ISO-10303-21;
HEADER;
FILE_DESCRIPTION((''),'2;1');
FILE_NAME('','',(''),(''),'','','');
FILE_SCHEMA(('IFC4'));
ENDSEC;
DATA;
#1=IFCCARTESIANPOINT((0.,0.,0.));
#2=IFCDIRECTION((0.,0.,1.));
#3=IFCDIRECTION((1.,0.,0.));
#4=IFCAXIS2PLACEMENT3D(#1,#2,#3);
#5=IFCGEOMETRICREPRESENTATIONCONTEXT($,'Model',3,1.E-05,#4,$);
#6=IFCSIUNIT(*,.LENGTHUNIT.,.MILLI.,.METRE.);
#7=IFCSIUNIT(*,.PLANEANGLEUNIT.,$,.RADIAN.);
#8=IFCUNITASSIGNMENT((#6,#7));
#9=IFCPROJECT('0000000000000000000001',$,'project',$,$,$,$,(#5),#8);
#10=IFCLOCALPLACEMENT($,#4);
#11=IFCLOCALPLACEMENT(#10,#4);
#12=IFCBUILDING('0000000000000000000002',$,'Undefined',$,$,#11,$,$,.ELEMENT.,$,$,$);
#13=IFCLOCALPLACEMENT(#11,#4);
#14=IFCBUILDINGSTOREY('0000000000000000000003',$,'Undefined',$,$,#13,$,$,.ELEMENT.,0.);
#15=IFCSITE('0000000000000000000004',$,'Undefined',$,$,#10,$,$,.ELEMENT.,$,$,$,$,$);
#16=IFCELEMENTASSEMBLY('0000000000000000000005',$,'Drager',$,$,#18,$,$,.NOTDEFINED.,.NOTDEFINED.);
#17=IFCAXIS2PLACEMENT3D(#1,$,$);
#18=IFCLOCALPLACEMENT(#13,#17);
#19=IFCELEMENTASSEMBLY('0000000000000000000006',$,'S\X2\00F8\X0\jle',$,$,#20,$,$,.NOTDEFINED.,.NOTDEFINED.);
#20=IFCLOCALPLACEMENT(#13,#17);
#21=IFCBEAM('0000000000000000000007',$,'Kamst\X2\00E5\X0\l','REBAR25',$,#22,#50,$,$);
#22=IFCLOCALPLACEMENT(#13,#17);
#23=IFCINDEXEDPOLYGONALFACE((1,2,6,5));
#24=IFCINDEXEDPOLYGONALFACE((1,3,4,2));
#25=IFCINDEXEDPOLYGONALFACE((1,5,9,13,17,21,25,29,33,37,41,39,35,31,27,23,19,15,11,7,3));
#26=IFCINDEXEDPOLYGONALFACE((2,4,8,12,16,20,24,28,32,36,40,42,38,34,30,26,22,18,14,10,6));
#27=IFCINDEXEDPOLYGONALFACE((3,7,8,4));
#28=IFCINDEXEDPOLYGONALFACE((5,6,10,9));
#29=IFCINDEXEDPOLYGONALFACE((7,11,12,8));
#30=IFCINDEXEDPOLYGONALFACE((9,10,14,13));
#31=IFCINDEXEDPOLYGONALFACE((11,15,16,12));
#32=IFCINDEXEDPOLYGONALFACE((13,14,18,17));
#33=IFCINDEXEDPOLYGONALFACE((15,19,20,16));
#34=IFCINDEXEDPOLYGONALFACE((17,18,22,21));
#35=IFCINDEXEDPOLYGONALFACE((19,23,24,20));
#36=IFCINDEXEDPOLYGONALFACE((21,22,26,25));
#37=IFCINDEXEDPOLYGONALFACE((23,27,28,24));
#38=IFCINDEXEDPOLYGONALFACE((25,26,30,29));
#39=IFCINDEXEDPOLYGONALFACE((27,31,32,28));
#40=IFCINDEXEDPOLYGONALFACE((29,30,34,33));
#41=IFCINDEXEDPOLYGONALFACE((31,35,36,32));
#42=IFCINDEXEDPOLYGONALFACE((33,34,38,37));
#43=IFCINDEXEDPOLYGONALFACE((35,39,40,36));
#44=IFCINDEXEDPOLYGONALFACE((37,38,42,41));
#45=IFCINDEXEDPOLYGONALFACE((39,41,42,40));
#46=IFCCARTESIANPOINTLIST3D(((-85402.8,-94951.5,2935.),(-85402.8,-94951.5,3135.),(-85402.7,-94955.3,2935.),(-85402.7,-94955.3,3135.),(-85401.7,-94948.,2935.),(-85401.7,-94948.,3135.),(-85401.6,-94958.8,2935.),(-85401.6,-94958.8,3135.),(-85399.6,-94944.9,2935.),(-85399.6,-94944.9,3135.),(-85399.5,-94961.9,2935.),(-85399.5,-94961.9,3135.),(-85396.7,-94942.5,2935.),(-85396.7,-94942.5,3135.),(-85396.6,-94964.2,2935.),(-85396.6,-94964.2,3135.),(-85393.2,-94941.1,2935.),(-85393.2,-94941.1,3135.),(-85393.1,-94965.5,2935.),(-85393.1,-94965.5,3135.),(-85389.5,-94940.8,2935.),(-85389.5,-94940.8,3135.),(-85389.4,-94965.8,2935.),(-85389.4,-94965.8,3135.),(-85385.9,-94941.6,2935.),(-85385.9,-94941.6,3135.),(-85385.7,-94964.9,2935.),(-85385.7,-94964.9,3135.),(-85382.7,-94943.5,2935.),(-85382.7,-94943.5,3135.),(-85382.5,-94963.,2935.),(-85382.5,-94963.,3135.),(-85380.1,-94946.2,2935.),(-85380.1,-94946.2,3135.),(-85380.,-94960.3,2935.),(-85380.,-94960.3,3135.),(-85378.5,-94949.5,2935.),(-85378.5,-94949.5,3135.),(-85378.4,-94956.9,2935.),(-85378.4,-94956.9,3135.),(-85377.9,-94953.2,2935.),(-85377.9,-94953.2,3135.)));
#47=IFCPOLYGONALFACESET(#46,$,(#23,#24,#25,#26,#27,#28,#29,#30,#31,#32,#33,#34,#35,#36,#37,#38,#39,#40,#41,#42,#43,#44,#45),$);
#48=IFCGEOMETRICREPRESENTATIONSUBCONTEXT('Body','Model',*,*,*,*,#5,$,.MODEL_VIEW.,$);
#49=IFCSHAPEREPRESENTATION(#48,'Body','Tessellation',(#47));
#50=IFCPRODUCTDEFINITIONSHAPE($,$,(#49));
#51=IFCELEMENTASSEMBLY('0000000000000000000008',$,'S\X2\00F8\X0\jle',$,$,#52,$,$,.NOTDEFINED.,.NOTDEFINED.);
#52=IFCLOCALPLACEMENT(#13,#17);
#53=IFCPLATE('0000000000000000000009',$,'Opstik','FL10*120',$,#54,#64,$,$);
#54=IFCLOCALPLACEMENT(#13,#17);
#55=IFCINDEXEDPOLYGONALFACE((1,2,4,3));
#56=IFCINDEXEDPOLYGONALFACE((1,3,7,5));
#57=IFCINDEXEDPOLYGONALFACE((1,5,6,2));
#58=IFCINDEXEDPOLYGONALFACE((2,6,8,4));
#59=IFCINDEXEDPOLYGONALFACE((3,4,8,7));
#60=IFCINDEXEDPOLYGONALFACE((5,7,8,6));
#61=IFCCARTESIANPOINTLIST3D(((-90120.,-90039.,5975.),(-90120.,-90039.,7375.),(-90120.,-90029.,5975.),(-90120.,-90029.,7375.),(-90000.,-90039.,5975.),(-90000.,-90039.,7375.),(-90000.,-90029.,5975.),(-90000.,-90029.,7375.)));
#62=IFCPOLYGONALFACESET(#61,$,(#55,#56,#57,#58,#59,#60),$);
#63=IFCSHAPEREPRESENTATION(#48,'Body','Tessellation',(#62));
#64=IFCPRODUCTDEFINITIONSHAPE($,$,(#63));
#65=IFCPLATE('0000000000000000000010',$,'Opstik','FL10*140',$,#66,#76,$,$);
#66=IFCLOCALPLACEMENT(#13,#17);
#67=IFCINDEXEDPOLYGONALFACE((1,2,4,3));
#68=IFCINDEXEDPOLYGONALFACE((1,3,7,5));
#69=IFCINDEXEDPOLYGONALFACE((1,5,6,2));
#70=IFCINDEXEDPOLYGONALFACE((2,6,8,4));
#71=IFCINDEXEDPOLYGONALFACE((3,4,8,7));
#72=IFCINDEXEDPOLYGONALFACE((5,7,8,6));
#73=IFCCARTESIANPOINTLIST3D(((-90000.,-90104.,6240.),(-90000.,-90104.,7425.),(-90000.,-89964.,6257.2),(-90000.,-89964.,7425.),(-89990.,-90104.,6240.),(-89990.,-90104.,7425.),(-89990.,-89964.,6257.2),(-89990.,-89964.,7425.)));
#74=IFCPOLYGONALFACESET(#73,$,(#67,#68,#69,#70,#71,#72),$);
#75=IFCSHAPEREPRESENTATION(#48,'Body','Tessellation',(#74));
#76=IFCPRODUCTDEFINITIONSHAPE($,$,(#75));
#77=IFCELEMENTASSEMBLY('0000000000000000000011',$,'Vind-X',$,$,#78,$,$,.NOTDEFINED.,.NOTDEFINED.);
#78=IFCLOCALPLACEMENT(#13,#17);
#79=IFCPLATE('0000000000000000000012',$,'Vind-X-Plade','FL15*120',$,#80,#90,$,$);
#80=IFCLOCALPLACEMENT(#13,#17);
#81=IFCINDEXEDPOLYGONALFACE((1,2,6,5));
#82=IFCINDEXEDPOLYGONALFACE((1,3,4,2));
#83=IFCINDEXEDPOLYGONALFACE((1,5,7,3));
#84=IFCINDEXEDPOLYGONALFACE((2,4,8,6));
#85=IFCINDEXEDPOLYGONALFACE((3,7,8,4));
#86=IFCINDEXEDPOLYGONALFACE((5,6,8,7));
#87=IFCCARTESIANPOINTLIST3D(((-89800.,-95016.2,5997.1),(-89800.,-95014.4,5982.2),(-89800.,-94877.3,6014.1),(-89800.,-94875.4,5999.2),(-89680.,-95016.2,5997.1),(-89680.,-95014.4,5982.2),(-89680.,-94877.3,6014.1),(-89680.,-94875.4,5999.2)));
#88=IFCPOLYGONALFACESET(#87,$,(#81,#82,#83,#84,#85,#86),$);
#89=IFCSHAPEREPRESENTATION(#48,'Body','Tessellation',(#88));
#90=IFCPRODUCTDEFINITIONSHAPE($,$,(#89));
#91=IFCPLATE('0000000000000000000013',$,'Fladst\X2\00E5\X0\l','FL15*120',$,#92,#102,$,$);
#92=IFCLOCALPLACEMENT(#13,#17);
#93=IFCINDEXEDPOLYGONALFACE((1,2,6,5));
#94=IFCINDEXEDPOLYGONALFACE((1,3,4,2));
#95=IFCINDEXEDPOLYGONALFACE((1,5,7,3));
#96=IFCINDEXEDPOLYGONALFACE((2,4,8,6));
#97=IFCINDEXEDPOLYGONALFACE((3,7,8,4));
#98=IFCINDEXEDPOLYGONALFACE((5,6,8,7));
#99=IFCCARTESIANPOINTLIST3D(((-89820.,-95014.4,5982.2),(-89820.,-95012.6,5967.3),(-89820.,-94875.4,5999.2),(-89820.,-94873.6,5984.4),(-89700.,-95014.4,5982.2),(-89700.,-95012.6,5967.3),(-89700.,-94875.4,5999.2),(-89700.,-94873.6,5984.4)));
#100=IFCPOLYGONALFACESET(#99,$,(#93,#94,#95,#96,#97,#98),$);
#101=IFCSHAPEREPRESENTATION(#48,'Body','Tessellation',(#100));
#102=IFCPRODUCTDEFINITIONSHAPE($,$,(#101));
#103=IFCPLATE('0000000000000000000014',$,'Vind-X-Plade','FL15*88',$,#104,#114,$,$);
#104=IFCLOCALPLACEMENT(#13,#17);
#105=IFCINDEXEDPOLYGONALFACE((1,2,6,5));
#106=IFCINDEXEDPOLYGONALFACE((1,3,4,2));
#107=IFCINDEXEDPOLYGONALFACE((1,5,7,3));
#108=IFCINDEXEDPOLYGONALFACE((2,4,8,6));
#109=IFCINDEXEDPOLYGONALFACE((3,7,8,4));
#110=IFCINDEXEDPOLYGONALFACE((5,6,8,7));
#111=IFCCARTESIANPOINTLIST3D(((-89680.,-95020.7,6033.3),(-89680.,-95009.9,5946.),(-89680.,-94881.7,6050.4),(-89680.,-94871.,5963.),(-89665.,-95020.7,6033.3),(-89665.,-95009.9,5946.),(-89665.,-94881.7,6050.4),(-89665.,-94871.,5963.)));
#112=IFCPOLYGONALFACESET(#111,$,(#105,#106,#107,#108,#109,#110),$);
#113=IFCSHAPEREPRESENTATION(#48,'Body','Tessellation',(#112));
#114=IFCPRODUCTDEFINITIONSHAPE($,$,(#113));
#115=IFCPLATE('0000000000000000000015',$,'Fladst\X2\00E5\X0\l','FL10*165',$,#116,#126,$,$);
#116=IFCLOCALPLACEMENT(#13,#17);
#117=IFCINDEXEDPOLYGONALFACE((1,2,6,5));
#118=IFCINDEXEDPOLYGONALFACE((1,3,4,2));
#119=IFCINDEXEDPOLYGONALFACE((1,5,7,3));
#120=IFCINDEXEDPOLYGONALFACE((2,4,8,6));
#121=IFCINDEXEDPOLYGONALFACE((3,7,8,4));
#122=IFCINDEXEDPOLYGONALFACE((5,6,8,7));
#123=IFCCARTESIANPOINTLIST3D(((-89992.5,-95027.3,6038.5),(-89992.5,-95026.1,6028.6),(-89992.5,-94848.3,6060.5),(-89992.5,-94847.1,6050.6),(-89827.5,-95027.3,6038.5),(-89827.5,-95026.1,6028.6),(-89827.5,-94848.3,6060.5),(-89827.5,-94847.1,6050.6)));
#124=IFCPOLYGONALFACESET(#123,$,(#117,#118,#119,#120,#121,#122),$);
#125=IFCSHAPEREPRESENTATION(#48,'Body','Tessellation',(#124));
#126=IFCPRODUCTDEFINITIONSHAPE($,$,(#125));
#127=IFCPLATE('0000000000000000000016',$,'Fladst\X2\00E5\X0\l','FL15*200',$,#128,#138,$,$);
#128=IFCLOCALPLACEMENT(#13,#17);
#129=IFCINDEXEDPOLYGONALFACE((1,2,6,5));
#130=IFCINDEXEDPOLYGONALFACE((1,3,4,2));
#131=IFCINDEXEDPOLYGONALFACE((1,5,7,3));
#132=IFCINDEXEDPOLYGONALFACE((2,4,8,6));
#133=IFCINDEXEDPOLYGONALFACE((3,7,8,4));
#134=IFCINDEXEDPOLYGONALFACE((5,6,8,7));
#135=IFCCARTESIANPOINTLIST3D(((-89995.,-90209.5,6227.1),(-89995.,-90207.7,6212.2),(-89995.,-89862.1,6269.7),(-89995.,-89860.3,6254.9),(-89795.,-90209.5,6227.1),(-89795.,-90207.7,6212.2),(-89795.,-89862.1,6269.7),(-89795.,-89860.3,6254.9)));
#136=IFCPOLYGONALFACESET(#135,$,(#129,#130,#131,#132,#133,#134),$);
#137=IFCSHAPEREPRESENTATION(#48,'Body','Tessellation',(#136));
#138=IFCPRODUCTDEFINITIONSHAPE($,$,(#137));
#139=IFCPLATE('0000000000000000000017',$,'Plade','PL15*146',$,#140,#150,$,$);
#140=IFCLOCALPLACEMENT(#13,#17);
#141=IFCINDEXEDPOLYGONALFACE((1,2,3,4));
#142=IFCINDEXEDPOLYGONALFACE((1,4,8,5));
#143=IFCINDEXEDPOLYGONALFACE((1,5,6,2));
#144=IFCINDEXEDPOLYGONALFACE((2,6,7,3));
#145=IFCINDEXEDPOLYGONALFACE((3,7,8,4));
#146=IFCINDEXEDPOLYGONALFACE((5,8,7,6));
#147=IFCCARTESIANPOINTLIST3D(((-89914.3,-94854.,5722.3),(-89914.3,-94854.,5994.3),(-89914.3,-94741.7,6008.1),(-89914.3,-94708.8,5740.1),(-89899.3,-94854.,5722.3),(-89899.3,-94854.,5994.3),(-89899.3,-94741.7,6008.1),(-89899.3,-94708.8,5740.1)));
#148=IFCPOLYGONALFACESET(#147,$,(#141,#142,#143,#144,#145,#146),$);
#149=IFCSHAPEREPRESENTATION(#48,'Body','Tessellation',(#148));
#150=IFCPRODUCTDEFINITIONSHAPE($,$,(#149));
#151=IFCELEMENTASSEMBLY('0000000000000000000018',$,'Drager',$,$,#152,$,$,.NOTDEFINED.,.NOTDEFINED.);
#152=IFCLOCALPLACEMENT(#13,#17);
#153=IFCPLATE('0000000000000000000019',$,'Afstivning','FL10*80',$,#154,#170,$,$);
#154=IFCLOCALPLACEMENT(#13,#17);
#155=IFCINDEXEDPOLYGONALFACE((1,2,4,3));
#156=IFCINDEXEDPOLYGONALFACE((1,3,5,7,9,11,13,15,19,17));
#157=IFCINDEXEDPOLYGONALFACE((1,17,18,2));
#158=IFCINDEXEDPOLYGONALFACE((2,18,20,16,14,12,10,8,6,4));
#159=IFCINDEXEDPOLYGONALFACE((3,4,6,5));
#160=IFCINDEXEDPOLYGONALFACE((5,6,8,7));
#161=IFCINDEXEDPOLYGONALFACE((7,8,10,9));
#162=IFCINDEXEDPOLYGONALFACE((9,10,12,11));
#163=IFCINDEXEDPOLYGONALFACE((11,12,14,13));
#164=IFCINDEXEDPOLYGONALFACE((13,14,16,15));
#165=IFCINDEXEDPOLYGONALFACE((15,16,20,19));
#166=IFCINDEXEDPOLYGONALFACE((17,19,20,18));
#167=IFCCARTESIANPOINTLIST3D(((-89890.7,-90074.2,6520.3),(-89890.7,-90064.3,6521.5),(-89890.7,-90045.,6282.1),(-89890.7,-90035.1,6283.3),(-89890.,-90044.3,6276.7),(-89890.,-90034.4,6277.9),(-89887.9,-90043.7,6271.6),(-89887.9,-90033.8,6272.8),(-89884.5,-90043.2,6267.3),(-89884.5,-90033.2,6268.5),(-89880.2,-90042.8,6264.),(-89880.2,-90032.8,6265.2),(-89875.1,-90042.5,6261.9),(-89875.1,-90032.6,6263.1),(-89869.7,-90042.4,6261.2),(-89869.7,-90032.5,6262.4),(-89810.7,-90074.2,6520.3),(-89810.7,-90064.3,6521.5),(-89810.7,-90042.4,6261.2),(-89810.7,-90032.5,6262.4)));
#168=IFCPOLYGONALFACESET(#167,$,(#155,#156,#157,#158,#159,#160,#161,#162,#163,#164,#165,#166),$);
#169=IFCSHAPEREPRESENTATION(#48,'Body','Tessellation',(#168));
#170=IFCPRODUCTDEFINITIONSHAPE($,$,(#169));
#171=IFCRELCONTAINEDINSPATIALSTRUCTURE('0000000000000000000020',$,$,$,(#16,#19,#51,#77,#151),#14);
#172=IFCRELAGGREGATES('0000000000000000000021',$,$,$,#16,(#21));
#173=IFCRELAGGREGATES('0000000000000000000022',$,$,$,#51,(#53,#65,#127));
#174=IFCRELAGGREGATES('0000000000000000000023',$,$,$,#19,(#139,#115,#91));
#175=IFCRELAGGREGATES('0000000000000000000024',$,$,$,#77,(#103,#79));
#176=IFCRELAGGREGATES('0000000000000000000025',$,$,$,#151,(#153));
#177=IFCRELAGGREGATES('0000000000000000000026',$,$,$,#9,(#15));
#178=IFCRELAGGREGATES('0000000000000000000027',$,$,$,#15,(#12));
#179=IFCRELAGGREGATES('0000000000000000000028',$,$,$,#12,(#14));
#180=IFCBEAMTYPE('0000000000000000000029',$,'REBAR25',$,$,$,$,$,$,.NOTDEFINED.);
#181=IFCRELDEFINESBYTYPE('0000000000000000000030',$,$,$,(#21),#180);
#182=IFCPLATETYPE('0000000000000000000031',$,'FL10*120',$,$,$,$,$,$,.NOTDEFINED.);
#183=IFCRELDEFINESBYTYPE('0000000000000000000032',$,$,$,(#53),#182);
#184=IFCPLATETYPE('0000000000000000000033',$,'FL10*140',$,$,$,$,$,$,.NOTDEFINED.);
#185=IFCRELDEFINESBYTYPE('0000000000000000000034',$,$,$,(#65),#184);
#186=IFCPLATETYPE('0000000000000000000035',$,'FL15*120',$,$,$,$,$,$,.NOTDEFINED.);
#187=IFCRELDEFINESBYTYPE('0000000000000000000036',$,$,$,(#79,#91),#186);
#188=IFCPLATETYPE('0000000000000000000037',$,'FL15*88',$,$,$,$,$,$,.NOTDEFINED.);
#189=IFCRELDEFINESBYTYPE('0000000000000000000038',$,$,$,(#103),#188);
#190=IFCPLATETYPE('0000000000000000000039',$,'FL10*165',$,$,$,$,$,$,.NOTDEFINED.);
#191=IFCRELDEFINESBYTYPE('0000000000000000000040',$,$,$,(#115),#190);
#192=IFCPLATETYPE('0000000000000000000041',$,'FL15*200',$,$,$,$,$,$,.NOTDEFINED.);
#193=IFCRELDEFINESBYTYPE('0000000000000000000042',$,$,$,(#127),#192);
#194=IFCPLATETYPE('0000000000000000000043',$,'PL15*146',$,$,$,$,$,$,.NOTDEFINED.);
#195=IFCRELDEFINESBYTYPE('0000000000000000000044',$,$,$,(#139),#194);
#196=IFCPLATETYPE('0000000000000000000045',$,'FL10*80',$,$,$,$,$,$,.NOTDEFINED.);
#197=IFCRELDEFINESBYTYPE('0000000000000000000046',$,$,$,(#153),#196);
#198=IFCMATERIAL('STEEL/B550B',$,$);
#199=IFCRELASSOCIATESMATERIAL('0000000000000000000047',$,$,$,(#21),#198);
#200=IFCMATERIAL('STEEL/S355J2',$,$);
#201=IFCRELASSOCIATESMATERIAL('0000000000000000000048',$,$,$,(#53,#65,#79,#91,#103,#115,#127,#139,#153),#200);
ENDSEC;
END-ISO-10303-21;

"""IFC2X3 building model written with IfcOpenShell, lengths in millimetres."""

from ifc_helpers import new_model, si_unit, frame, frame_2d, origin_with_axes, origin_2d_with_axis, place, context, subcontext, project, spatial, polyline, circle_curve, parameter, trimmed, segment, composite_curve, circle, outline, extrude, material, type_object, element, aggregate, save


model = new_model("IFC2X3")

# Units and contexts
model_context = context("Model", 3, precision=1e-05, world=origin_with_axes())
body_context = subcontext(model_context, "Body", "Model", "MODEL_VIEW")
ifc_project = project(units=[si_unit("LENGTHUNIT", "METRE", prefix="MILLI"), si_unit("PLANEANGLEUNIT", "RADIAN")], contexts=[model_context])

# Site, building, storey
site_placement = place(None, origin_with_axes())
site = spatial("IfcSite", under=ifc_project, at=site_placement, Name="Undefined", CompositionType="ELEMENT")
building_placement = place(site_placement, origin_with_axes())
building = spatial("IfcBuilding", under=site, at=building_placement, Name="Undefined", CompositionType="ELEMENT")
storey_placement = place(building_placement, origin_with_axes())
storey = spatial("IfcBuildingStorey", under=building, at=storey_placement, Name="Undefined", CompositionType="ELEMENT", Elevation=0.0)

# Element assembly
assembly_1_placement = place(storey_placement, origin_with_axes())
assembly_1 = element("IfcElementAssembly", 1, at=assembly_1_placement, inside=storey, Name="Drager", AssemblyPlace="NOTDEFINED", PredefinedType="NOTDEFINED")
ifc_material_1 = material(Name="STEEL/B550B")

# Element assembly
assembly_2_placement = place(storey_placement, origin_with_axes())
assembly_2 = element("IfcElementAssembly", 2, at=assembly_2_placement, inside=storey, Name="Søjle", AssemblyPlace="NOTDEFINED", PredefinedType="NOTDEFINED")
ifc_material_2 = material(Name="STEEL/S355J2")

# Beam
beam_type_1 = type_object("IfcBeamType", Name="REBAR25", PredefinedType="NOTDEFINED")
beam_1_placement = place(assembly_1_placement, frame((-85390.4, -94953.3, 3135.0), z_axis=(-0.862746, -0.505638, 0.0), x_axis=(0.0, 0.0, -1.0)))
beam_1 = element("IfcBeam", 3, at=beam_1_placement, type_object=beam_type_1, material=ifc_material_1, Name="Kamstål", Description="REBAR25", context=body_context, shape_type="SweptSolid", body=[
    extrude(circle(Radius=12.5, at=origin_2d_with_axis()), frame((200.0, 0.0, 0.0), z_axis=(-1.0, 0.0, 0.0), x_axis=(0.0, -1.0, 0.0)), (0.0, 0.0, 1.0), 200.0),
])
aggregate(assembly_1, [beam_1])

# Element assembly, plates
assembly_3_placement = place(storey_placement, origin_with_axes())
assembly_3 = element("IfcElementAssembly", 4, at=assembly_3_placement, inside=storey, Name="Søjle", AssemblyPlace="NOTDEFINED", PredefinedType="NOTDEFINED")
plate_type_1 = type_object("IfcPlateType", Name="FL10*120", PredefinedType="NOTDEFINED")
plate_1_placement = place(assembly_3_placement, frame((-90000.0, -90034.0, 5975.0), z_axis=(0.0, -1.0, 0.0), x_axis=(0.0, 0.0, 1.0)))
plate_1 = element("IfcPlate", 5, at=plate_1_placement, type_object=plate_type_1, material=ifc_material_2, Name="Opstik", Description="FL10*120", context=body_context, shape_type="SweptSolid", body=[
    extrude(outline(polyline([(0.0, 0.0), (1400.0, 0.0), (1400.0, 120.0), (1400.0, 120.0), (0.0, 120.0), (0.0, 120.0), (0.0, 0.0)])), frame((0.0, 0.0, -5.0), z_axis=(0.0, 0.0, 1.0), x_axis=(1.0, 0.0, 0.0)), (0.0, 0.0, 1.0), 10.0),
])
plate_type_2 = type_object("IfcPlateType", Name="FL10*140", PredefinedType="NOTDEFINED")
plate_2_placement = place(assembly_3_placement, frame((-89995.0, -90104.0, 6240.0), z_axis=(-1.0, 0.0, 0.0), x_axis=(0.0, 0.0, 1.0)))
plate_2 = element("IfcPlate", 6, at=plate_2_placement, type_object=plate_type_2, material=ifc_material_2, Name="Opstik", Description="FL10*140", context=body_context, shape_type="SweptSolid", body=[
    extrude(outline(polyline([(0.0, 0.0), (1185.0, 0.0), (1185.0, 0.0), (1185.0, 140.0), (1185.0, 140.0), (17.2, 140.0), (0.0, 0.0)])), frame((0.0, 0.0, -5.0), z_axis=(0.0, 0.0, 1.0), x_axis=(1.0, 0.0, 0.0)), (0.0, 0.0, 1.0), 10.0),
])

# Element assembly, plate
assembly_4_placement = place(storey_placement, origin_with_axes())
assembly_4 = element("IfcElementAssembly", 7, at=assembly_4_placement, inside=storey, Name="Vind-X", AssemblyPlace="NOTDEFINED", PredefinedType="NOTDEFINED")
plate_type_3 = type_object("IfcPlateType", Name="FL15*120", PredefinedType="NOTDEFINED")
plate_3_placement = place(assembly_4_placement, frame((-89800.0, -94945.8, 5998.2), z_axis=(0.0, 0.121869, -0.992546), x_axis=(1.0, 0.0, 0.0)))
plate_3 = element("IfcPlate", 8, at=plate_3_placement, type_object=plate_type_3, material=ifc_material_2, Name="Vind-X-Plade", Description="FL15*120", context=body_context, shape_type="SweptSolid", body=[
    extrude(outline(polyline([(0.0, -70.0), (0.0, 70.0), (120.0, 70.0), (120.0, -70.0), (0.0, -70.0)])), frame((0.0, 0.0, -7.5), z_axis=(0.0, 0.0, 1.0), x_axis=(1.0, 0.0, 0.0)), (0.0, 0.0, 1.0), 15.0),
])

# Plates
plate_4_placement = place(assembly_2_placement, frame((-89820.0, -94874.5, 5991.8), z_axis=(0.0, -0.121869, 0.992546), x_axis=(0.0, -0.992546, -0.121869)))
plate_4 = element("IfcPlate", 9, at=plate_4_placement, type_object=plate_type_3, material=ifc_material_2, Name="Fladstål", Description="FL15*120", context=body_context, shape_type="SweptSolid", body=[
    extrude(outline(polyline([(0.0, 0.0), (140.0, 0.0), (140.0, 120.0), (0.0, 120.0), (0.0, 0.0)])), frame((0.0, 0.0, -7.5), z_axis=(0.0, 0.0, 1.0), x_axis=(1.0, 0.0, 0.0)), (0.0, 0.0, 1.0), 15.0),
])
plate_type_4 = type_object("IfcPlateType", Name="FL15*88", PredefinedType="NOTDEFINED")
plate_5_placement = place(assembly_4_placement, frame((-89672.5, -94871.0, 5963.0), z_axis=(-1.0, 0.0, 0.0), x_axis=(0.0, -0.992546, -0.121869)))
plate_5 = element("IfcPlate", 10, at=plate_5_placement, type_object=plate_type_4, material=ifc_material_2, Name="Vind-X-Plade", Description="FL15*88", context=body_context, shape_type="SweptSolid", body=[
    extrude(outline(polyline([(0.0, 0.0), (140.0, 0.0), (140.0, 88.0), (0.0, 88.0), (0.0, 0.0)])), frame((0.0, 0.0, -7.5), z_axis=(0.0, 0.0, 1.0), x_axis=(1.0, 0.0, 0.0)), (0.0, 0.0, 1.0), 15.0),
])
plate_type_5 = type_object("IfcPlateType", Name="FL10*165", PredefinedType="NOTDEFINED")
plate_6_placement = place(assembly_2_placement, frame((-89910.0, -95026.7, 6033.6), z_axis=(0.0, 0.121869, -0.992546), x_axis=(0.0, 0.992546, 0.121869)))
plate_6 = element("IfcPlate", 11, at=plate_6_placement, type_object=plate_type_5, material=ifc_material_2, Name="Fladstål", Description="FL10*165", context=body_context, shape_type="SweptSolid", body=[
    extrude(outline(polyline([(0.0, -82.5), (0.0, 82.5), (180.4, 82.5), (180.4, -82.5), (0.0, -82.5)])), frame((0.0, 0.0, -5.0), z_axis=(0.0, 0.0, 1.0), x_axis=(1.0, 0.0, 0.0)), (0.0, 0.0, 1.0), 10.0),
])
plate_type_6 = type_object("IfcPlateType", Name="FL15*200", PredefinedType="NOTDEFINED")
plate_7_placement = place(assembly_3_placement, frame((-89895.0, -90208.6, 6219.6), z_axis=(0.0, 0.121869, -0.992546), x_axis=(0.0, 0.992546, 0.121869)))
plate_7 = element("IfcPlate", 12, at=plate_7_placement, type_object=plate_type_6, material=ifc_material_2, Name="Fladstål", Description="FL15*200", context=body_context, shape_type="SweptSolid", body=[
    extrude(outline(polyline([(0.0, -100.0), (0.0, 100.0), (350.0, 100.0), (350.0, -100.0), (0.0, -100.0)])), frame((0.0, 0.0, -7.5), z_axis=(0.0, 0.0, 1.0), x_axis=(1.0, 0.0, 0.0)), (0.0, 0.0, 1.0), 15.0),
])
aggregate(assembly_3, [plate_1, plate_2, plate_7])
plate_type_7 = type_object("IfcPlateType", Name="PL15*146", PredefinedType="NOTDEFINED")
plate_8_placement = place(assembly_2_placement, frame((-89906.8, -94854.0, 5994.3), z_axis=(1.0, 0.0, 0.0), x_axis=(0.0, 0.0, -1.0)))
plate_8 = element("IfcPlate", 13, at=plate_8_placement, type_object=plate_type_7, material=ifc_material_2, Name="Plade", Description="PL15*146", context=body_context, shape_type="SweptSolid", body=[
    extrude(outline(polyline([(0.0, 0.0), (272.0, 0.0), (254.2, 145.2), (-13.8, 112.3), (0.0, 0.0)])), frame((0.0, 0.0, -7.5), z_axis=(0.0, 0.0, 1.0), x_axis=(1.0, 0.0, 0.0)), (0.0, 0.0, 1.0), 15.0),
])
aggregate(assembly_2, [plate_8, plate_6, plate_4])

# Element assembly, plate
assembly_5_placement = place(storey_placement, origin_with_axes())
assembly_5 = element("IfcElementAssembly", 14, at=assembly_5_placement, inside=storey, Name="Drager", AssemblyPlace="NOTDEFINED", PredefinedType="NOTDEFINED")
plate_type_8 = type_object("IfcPlateType", Name="FL10*80", PredefinedType="NOTDEFINED")
plate_9_placement = place(assembly_5_placement, frame((-89890.7, -90037.5, 6261.8), z_axis=(0.0, -0.992546, -0.121869), x_axis=(1.0, 0.0, 0.0)))
plate_9 = element("IfcPlate", 15, at=plate_9_placement, type_object=plate_type_8, material=ifc_material_2, Name="Afstivning", Description="FL10*80", context=body_context, shape_type="SweptSolid", body=[
    extrude(outline(composite_curve([segment(trimmed(circle_curve(frame_2d((21.0, 21.0), x_axis=(-1.0, 0.0)), 21.0), [parameter(0.0)], [parameter(1.570796)], True, "PARAMETER"), True, "CONTINUOUS"), segment(polyline([(21.0, 0.0), (80.0, 0.0), (80.0, 261.0), (0.0, 261.0), (0.0, 21.0)]), True, "CONTINUOUS")], self_intersect=True)), frame((0.0, 0.0, -5.0), z_axis=(0.0, 0.0, 1.0), x_axis=(1.0, 0.0, 0.0)), (0.0, 0.0, 1.0), 10.0),
])

aggregate(assembly_4, [plate_5, plate_3])
aggregate(assembly_5, [plate_9])

save(model, "model.ifc")
